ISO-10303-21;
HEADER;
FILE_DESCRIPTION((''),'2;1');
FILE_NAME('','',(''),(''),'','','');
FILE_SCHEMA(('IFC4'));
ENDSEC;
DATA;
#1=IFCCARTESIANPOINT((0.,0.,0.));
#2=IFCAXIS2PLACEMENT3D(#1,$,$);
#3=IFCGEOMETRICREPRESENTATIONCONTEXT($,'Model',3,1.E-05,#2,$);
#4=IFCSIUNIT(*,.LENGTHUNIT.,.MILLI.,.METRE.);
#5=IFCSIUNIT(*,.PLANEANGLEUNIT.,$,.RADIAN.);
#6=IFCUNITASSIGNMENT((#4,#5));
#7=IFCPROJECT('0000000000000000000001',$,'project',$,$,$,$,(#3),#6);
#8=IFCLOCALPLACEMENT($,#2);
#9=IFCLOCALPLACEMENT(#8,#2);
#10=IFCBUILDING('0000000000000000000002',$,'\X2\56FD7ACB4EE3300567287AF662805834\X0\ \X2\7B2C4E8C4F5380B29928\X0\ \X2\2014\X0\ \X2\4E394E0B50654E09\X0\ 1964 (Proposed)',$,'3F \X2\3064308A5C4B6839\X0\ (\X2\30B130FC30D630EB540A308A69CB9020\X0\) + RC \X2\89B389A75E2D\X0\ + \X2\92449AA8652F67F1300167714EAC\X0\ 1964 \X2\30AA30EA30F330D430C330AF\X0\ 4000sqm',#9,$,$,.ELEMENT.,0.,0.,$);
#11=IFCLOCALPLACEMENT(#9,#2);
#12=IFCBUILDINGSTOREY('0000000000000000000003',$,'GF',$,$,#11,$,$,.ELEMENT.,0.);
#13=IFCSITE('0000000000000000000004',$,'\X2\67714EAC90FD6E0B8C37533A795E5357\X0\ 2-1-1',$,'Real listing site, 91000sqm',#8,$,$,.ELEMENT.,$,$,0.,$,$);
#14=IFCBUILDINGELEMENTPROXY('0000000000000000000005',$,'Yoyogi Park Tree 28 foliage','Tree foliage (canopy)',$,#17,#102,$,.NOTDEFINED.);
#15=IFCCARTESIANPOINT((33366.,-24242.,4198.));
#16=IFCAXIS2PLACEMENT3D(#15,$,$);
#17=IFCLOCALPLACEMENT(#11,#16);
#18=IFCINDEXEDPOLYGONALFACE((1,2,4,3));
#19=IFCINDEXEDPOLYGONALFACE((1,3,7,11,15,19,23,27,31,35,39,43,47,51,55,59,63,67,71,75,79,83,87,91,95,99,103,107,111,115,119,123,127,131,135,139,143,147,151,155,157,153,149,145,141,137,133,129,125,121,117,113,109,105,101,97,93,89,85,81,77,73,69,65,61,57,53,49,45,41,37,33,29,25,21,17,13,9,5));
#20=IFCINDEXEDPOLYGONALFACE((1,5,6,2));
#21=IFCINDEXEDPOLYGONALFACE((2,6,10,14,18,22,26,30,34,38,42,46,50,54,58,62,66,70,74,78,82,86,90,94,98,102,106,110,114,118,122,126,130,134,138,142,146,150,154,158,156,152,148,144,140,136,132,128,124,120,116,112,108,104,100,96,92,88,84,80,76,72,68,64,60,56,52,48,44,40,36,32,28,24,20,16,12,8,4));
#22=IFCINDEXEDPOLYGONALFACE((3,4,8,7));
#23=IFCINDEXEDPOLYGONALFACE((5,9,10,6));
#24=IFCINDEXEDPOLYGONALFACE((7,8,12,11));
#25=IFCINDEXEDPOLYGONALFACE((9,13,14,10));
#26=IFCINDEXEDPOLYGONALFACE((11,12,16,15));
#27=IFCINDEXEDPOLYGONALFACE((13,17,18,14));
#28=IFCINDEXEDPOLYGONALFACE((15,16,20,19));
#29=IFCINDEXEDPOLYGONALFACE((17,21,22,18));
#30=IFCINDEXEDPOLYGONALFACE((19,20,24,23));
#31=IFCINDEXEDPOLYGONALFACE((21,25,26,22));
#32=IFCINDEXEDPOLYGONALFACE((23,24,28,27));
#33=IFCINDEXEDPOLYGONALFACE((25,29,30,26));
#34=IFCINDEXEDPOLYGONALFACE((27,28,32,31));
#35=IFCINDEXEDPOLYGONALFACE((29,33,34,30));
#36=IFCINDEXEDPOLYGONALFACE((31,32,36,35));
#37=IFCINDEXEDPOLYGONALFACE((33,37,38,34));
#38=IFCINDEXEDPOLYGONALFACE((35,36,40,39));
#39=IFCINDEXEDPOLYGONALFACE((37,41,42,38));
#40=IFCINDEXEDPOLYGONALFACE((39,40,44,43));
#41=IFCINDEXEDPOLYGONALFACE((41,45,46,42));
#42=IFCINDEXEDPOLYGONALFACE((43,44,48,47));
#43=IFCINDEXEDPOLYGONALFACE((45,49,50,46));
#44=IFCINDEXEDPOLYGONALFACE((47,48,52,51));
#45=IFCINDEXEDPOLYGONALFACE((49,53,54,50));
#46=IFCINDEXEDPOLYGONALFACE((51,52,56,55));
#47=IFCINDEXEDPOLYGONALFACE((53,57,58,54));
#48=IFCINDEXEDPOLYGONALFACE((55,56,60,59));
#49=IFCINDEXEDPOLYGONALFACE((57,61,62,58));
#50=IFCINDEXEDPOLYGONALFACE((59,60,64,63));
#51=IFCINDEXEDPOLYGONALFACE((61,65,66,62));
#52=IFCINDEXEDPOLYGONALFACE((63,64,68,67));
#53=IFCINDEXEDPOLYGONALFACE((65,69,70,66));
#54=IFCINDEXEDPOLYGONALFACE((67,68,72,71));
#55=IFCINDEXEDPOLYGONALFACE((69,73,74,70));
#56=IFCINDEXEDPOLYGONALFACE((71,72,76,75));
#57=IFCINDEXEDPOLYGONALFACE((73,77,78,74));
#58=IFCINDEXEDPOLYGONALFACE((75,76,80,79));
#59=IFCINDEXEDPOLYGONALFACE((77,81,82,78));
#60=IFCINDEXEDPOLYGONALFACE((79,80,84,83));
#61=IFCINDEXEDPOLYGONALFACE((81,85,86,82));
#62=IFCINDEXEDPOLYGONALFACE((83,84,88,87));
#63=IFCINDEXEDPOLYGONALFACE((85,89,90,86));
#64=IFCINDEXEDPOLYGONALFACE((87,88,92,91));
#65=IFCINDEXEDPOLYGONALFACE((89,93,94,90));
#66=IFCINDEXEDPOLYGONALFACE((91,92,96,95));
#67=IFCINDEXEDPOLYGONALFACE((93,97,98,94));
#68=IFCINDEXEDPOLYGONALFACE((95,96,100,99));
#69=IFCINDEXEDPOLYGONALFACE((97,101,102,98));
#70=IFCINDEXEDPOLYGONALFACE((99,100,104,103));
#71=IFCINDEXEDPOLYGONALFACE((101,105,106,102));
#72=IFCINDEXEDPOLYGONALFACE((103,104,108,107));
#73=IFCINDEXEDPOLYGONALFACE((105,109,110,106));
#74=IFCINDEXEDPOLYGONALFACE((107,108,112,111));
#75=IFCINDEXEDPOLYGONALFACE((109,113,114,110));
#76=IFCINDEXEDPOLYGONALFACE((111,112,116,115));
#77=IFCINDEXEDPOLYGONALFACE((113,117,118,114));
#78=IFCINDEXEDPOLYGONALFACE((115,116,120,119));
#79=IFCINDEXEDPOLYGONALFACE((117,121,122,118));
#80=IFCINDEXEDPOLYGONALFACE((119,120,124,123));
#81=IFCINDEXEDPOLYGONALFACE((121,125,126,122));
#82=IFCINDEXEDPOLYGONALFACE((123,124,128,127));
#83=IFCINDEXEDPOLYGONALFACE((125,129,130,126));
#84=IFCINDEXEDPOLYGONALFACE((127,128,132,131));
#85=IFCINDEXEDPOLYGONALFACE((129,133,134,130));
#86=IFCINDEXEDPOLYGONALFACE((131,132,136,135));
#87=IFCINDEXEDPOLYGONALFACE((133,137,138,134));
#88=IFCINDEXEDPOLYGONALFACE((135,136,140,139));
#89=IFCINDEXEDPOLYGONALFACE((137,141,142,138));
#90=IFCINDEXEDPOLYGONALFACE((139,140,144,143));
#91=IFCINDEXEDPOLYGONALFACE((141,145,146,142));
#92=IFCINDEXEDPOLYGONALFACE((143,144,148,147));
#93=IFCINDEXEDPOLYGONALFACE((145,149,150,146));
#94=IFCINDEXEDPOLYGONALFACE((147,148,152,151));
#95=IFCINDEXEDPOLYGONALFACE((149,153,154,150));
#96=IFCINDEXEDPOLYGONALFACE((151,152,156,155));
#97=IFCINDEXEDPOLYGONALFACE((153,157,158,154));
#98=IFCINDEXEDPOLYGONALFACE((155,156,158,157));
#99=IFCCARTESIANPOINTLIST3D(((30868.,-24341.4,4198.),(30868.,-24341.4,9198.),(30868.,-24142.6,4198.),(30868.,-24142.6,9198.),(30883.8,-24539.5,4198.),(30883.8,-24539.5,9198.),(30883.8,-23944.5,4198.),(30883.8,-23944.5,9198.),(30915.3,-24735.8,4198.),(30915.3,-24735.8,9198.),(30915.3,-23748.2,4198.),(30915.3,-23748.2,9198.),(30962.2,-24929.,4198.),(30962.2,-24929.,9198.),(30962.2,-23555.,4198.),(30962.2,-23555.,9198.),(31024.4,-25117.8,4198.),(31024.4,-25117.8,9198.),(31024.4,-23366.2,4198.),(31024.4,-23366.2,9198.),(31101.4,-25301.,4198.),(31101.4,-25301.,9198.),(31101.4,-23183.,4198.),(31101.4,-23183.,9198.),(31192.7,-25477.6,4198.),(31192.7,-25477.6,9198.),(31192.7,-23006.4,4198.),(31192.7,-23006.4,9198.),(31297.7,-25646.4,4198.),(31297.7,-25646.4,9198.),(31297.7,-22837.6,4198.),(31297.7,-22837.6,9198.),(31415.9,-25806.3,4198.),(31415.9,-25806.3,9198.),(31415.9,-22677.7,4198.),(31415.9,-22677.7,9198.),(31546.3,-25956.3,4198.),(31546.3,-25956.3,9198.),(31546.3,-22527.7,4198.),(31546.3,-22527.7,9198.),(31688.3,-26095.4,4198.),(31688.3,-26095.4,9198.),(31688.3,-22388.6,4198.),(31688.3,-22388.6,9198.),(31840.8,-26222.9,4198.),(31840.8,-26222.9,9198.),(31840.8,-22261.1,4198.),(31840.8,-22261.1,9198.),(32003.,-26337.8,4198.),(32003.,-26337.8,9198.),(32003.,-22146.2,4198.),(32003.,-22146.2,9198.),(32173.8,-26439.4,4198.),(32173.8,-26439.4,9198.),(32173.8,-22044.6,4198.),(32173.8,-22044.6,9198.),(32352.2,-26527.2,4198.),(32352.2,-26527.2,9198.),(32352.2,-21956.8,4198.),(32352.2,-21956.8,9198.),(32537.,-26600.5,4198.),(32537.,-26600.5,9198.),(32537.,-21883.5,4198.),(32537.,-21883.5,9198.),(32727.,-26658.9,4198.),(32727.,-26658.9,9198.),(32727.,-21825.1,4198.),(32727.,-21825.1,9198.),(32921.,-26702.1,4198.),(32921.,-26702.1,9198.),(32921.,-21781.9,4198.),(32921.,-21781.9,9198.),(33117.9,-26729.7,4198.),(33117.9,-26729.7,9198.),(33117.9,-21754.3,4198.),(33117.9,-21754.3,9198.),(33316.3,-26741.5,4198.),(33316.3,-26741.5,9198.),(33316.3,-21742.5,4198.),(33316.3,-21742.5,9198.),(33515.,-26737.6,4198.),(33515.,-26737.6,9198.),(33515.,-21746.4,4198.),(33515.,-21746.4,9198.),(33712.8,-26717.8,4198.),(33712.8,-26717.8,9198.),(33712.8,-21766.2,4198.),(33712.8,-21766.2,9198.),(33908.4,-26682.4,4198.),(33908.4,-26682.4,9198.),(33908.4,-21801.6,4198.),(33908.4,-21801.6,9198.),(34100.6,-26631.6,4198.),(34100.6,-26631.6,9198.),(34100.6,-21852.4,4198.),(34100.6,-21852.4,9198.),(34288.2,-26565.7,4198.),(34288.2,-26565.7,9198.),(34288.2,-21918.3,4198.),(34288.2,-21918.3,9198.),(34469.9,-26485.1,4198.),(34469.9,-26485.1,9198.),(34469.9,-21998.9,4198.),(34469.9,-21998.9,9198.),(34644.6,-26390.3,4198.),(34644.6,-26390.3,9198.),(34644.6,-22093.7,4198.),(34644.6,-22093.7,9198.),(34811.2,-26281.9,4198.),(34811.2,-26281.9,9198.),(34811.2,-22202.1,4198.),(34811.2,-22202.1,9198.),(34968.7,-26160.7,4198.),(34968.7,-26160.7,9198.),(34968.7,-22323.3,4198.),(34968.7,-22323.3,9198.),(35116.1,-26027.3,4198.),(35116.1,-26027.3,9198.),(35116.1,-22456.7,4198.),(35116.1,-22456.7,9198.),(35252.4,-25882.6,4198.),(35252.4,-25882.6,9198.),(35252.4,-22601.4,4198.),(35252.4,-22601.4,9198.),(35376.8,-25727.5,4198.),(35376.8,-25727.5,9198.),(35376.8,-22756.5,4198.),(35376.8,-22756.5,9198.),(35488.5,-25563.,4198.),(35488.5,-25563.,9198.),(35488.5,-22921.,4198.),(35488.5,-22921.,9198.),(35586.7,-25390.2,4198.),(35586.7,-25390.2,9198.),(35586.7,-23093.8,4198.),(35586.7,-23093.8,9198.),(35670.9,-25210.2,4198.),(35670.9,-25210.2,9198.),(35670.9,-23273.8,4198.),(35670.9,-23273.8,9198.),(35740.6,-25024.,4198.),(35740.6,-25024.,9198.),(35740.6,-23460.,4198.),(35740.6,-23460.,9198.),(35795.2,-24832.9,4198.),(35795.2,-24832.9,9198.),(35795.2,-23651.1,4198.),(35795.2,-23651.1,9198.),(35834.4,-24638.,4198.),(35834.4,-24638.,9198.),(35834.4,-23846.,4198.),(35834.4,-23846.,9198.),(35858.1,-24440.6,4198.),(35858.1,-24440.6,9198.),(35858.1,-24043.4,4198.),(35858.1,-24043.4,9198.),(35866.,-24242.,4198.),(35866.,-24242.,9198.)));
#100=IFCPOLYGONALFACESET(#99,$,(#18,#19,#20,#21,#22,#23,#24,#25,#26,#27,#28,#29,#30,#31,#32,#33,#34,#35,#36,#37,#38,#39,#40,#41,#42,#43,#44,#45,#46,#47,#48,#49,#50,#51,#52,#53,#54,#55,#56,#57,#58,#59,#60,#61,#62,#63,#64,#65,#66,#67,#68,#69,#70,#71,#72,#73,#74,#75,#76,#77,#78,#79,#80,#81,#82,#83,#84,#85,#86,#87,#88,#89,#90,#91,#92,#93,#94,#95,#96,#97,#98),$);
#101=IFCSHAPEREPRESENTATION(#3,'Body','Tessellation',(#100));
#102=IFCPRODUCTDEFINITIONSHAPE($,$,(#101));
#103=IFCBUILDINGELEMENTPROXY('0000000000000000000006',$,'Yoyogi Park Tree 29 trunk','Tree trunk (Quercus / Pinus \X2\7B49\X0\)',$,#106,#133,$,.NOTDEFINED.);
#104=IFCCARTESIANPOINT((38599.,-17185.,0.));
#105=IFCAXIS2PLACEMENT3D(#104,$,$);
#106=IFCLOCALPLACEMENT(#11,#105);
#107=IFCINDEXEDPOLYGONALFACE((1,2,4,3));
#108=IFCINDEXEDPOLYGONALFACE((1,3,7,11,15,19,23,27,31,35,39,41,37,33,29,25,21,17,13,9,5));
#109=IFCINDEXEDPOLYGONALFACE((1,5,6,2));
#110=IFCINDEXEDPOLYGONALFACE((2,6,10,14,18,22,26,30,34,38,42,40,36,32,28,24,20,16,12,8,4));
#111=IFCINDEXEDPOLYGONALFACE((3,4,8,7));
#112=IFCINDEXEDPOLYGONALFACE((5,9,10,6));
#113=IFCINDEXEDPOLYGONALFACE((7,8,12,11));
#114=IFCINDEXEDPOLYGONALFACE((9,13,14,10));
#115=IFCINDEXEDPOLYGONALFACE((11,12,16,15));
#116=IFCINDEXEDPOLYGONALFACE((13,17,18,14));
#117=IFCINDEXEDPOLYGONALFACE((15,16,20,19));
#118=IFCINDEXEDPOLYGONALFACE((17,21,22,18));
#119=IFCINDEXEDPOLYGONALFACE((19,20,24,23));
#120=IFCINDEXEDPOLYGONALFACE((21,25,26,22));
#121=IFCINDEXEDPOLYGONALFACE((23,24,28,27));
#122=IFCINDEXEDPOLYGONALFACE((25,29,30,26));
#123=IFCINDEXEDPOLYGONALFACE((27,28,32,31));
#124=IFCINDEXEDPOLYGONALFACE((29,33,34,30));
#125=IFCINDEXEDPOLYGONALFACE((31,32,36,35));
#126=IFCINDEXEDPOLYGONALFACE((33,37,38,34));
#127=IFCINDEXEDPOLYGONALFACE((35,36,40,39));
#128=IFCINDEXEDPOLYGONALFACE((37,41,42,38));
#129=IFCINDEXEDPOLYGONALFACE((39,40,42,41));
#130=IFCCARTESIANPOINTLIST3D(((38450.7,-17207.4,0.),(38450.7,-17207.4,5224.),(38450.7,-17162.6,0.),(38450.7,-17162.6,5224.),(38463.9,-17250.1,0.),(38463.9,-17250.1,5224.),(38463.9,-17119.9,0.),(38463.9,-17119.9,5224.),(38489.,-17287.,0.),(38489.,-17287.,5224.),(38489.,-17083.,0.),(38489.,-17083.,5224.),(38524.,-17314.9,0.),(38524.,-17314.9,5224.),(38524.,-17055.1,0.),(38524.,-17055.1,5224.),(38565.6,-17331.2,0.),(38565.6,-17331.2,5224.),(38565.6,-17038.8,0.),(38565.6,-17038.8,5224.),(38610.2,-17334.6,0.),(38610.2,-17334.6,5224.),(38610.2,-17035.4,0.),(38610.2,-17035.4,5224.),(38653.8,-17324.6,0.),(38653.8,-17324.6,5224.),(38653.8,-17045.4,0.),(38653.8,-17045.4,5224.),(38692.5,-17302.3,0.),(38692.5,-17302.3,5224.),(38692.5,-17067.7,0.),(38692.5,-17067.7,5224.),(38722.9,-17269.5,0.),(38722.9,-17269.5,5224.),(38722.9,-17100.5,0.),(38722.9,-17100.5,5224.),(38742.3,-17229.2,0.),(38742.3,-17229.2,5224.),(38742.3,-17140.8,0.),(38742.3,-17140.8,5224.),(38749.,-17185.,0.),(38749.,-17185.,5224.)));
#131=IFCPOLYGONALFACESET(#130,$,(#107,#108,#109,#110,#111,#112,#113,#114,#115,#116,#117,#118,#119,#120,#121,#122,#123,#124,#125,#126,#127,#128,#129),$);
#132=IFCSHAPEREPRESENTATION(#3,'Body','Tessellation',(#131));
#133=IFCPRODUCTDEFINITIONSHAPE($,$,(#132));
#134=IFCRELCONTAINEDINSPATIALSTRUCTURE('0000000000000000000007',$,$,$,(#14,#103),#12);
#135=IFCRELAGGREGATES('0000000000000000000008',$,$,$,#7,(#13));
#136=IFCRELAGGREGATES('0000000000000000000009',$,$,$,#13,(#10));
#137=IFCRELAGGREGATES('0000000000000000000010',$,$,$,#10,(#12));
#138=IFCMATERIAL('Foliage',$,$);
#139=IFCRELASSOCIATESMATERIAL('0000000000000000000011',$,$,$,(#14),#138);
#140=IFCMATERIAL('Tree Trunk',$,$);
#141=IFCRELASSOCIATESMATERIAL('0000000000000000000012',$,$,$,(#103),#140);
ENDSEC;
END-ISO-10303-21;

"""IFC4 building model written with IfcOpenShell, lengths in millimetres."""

from ifc_helpers import new_model, si_unit, frame, origin, origin_2d, place, context, project, spatial, circle, extrude, material, element, save


model = new_model("IFC4")

# Units and contexts
model_context = context("Model", 3, precision=1e-05, world=origin())
ifc_project = project(units=[si_unit("LENGTHUNIT", "METRE", prefix="MILLI"), si_unit("PLANEANGLEUNIT", "RADIAN")], contexts=[model_context])

# Site, building, storey
site_placement = place(None, origin())
site = spatial("IfcSite", under=ifc_project, at=site_placement, Name="東京都渋谷区神南 2-1-1", ObjectType="Real listing site, 91000sqm", CompositionType="ELEMENT", RefElevation=0.0)
building_placement = place(site_placement, origin())
building = spatial("IfcBuilding", under=site, at=building_placement, Name="国立代々木競技場 第二体育館 — 丹下健三 1964 (Proposed)", ObjectType="3F つり屋根 (ケーブル吊り構造) + RC 観覧席 + 鉄骨支柱、東京 1964 オリンピック 4000sqm", CompositionType="ELEMENT", ElevationOfRefHeight=0.0, ElevationOfTerrain=0.0)
storey_placement = place(building_placement, origin())
storey = spatial("IfcBuildingStorey", under=building, at=storey_placement, Name="GF", CompositionType="ELEMENT", Elevation=0.0)

# Building element proxies
ifc_material_1 = material(Name="Tree Trunk")
ifc_material_2 = material(Name="Foliage")
proxy_1_placement = place(storey_placement, frame((33366.0, -24242.0, 4198.0)))
element("IfcBuildingElementProxy", 1, at=proxy_1_placement, inside=storey, material=ifc_material_2, Name="Yoyogi Park Tree 28 foliage", Description="Tree foliage (canopy)", PredefinedType="NOTDEFINED", context=model_context, shape_type="SweptSolid", body=[
    extrude(circle(Radius=2500.0, at=origin_2d()), frame((33366.0, -24242.0, 4198.0)), (0.0, 0.0, 1.0), 5000.0),
])
proxy_2_placement = place(storey_placement, frame((38599.0, -17185.0, 0.0)))
element("IfcBuildingElementProxy", 2, at=proxy_2_placement, inside=storey, material=ifc_material_1, Name="Yoyogi Park Tree 29 trunk", Description="Tree trunk (Quercus / Pinus 等)", PredefinedType="NOTDEFINED", context=model_context, shape_type="SweptSolid", body=[
    extrude(circle(Radius=150.0, at=origin_2d()), frame((38599.0, -17185.0, 0.0)), (0.0, 0.0, 1.0), 5224.0),
])

save(model, "model.ifc")
